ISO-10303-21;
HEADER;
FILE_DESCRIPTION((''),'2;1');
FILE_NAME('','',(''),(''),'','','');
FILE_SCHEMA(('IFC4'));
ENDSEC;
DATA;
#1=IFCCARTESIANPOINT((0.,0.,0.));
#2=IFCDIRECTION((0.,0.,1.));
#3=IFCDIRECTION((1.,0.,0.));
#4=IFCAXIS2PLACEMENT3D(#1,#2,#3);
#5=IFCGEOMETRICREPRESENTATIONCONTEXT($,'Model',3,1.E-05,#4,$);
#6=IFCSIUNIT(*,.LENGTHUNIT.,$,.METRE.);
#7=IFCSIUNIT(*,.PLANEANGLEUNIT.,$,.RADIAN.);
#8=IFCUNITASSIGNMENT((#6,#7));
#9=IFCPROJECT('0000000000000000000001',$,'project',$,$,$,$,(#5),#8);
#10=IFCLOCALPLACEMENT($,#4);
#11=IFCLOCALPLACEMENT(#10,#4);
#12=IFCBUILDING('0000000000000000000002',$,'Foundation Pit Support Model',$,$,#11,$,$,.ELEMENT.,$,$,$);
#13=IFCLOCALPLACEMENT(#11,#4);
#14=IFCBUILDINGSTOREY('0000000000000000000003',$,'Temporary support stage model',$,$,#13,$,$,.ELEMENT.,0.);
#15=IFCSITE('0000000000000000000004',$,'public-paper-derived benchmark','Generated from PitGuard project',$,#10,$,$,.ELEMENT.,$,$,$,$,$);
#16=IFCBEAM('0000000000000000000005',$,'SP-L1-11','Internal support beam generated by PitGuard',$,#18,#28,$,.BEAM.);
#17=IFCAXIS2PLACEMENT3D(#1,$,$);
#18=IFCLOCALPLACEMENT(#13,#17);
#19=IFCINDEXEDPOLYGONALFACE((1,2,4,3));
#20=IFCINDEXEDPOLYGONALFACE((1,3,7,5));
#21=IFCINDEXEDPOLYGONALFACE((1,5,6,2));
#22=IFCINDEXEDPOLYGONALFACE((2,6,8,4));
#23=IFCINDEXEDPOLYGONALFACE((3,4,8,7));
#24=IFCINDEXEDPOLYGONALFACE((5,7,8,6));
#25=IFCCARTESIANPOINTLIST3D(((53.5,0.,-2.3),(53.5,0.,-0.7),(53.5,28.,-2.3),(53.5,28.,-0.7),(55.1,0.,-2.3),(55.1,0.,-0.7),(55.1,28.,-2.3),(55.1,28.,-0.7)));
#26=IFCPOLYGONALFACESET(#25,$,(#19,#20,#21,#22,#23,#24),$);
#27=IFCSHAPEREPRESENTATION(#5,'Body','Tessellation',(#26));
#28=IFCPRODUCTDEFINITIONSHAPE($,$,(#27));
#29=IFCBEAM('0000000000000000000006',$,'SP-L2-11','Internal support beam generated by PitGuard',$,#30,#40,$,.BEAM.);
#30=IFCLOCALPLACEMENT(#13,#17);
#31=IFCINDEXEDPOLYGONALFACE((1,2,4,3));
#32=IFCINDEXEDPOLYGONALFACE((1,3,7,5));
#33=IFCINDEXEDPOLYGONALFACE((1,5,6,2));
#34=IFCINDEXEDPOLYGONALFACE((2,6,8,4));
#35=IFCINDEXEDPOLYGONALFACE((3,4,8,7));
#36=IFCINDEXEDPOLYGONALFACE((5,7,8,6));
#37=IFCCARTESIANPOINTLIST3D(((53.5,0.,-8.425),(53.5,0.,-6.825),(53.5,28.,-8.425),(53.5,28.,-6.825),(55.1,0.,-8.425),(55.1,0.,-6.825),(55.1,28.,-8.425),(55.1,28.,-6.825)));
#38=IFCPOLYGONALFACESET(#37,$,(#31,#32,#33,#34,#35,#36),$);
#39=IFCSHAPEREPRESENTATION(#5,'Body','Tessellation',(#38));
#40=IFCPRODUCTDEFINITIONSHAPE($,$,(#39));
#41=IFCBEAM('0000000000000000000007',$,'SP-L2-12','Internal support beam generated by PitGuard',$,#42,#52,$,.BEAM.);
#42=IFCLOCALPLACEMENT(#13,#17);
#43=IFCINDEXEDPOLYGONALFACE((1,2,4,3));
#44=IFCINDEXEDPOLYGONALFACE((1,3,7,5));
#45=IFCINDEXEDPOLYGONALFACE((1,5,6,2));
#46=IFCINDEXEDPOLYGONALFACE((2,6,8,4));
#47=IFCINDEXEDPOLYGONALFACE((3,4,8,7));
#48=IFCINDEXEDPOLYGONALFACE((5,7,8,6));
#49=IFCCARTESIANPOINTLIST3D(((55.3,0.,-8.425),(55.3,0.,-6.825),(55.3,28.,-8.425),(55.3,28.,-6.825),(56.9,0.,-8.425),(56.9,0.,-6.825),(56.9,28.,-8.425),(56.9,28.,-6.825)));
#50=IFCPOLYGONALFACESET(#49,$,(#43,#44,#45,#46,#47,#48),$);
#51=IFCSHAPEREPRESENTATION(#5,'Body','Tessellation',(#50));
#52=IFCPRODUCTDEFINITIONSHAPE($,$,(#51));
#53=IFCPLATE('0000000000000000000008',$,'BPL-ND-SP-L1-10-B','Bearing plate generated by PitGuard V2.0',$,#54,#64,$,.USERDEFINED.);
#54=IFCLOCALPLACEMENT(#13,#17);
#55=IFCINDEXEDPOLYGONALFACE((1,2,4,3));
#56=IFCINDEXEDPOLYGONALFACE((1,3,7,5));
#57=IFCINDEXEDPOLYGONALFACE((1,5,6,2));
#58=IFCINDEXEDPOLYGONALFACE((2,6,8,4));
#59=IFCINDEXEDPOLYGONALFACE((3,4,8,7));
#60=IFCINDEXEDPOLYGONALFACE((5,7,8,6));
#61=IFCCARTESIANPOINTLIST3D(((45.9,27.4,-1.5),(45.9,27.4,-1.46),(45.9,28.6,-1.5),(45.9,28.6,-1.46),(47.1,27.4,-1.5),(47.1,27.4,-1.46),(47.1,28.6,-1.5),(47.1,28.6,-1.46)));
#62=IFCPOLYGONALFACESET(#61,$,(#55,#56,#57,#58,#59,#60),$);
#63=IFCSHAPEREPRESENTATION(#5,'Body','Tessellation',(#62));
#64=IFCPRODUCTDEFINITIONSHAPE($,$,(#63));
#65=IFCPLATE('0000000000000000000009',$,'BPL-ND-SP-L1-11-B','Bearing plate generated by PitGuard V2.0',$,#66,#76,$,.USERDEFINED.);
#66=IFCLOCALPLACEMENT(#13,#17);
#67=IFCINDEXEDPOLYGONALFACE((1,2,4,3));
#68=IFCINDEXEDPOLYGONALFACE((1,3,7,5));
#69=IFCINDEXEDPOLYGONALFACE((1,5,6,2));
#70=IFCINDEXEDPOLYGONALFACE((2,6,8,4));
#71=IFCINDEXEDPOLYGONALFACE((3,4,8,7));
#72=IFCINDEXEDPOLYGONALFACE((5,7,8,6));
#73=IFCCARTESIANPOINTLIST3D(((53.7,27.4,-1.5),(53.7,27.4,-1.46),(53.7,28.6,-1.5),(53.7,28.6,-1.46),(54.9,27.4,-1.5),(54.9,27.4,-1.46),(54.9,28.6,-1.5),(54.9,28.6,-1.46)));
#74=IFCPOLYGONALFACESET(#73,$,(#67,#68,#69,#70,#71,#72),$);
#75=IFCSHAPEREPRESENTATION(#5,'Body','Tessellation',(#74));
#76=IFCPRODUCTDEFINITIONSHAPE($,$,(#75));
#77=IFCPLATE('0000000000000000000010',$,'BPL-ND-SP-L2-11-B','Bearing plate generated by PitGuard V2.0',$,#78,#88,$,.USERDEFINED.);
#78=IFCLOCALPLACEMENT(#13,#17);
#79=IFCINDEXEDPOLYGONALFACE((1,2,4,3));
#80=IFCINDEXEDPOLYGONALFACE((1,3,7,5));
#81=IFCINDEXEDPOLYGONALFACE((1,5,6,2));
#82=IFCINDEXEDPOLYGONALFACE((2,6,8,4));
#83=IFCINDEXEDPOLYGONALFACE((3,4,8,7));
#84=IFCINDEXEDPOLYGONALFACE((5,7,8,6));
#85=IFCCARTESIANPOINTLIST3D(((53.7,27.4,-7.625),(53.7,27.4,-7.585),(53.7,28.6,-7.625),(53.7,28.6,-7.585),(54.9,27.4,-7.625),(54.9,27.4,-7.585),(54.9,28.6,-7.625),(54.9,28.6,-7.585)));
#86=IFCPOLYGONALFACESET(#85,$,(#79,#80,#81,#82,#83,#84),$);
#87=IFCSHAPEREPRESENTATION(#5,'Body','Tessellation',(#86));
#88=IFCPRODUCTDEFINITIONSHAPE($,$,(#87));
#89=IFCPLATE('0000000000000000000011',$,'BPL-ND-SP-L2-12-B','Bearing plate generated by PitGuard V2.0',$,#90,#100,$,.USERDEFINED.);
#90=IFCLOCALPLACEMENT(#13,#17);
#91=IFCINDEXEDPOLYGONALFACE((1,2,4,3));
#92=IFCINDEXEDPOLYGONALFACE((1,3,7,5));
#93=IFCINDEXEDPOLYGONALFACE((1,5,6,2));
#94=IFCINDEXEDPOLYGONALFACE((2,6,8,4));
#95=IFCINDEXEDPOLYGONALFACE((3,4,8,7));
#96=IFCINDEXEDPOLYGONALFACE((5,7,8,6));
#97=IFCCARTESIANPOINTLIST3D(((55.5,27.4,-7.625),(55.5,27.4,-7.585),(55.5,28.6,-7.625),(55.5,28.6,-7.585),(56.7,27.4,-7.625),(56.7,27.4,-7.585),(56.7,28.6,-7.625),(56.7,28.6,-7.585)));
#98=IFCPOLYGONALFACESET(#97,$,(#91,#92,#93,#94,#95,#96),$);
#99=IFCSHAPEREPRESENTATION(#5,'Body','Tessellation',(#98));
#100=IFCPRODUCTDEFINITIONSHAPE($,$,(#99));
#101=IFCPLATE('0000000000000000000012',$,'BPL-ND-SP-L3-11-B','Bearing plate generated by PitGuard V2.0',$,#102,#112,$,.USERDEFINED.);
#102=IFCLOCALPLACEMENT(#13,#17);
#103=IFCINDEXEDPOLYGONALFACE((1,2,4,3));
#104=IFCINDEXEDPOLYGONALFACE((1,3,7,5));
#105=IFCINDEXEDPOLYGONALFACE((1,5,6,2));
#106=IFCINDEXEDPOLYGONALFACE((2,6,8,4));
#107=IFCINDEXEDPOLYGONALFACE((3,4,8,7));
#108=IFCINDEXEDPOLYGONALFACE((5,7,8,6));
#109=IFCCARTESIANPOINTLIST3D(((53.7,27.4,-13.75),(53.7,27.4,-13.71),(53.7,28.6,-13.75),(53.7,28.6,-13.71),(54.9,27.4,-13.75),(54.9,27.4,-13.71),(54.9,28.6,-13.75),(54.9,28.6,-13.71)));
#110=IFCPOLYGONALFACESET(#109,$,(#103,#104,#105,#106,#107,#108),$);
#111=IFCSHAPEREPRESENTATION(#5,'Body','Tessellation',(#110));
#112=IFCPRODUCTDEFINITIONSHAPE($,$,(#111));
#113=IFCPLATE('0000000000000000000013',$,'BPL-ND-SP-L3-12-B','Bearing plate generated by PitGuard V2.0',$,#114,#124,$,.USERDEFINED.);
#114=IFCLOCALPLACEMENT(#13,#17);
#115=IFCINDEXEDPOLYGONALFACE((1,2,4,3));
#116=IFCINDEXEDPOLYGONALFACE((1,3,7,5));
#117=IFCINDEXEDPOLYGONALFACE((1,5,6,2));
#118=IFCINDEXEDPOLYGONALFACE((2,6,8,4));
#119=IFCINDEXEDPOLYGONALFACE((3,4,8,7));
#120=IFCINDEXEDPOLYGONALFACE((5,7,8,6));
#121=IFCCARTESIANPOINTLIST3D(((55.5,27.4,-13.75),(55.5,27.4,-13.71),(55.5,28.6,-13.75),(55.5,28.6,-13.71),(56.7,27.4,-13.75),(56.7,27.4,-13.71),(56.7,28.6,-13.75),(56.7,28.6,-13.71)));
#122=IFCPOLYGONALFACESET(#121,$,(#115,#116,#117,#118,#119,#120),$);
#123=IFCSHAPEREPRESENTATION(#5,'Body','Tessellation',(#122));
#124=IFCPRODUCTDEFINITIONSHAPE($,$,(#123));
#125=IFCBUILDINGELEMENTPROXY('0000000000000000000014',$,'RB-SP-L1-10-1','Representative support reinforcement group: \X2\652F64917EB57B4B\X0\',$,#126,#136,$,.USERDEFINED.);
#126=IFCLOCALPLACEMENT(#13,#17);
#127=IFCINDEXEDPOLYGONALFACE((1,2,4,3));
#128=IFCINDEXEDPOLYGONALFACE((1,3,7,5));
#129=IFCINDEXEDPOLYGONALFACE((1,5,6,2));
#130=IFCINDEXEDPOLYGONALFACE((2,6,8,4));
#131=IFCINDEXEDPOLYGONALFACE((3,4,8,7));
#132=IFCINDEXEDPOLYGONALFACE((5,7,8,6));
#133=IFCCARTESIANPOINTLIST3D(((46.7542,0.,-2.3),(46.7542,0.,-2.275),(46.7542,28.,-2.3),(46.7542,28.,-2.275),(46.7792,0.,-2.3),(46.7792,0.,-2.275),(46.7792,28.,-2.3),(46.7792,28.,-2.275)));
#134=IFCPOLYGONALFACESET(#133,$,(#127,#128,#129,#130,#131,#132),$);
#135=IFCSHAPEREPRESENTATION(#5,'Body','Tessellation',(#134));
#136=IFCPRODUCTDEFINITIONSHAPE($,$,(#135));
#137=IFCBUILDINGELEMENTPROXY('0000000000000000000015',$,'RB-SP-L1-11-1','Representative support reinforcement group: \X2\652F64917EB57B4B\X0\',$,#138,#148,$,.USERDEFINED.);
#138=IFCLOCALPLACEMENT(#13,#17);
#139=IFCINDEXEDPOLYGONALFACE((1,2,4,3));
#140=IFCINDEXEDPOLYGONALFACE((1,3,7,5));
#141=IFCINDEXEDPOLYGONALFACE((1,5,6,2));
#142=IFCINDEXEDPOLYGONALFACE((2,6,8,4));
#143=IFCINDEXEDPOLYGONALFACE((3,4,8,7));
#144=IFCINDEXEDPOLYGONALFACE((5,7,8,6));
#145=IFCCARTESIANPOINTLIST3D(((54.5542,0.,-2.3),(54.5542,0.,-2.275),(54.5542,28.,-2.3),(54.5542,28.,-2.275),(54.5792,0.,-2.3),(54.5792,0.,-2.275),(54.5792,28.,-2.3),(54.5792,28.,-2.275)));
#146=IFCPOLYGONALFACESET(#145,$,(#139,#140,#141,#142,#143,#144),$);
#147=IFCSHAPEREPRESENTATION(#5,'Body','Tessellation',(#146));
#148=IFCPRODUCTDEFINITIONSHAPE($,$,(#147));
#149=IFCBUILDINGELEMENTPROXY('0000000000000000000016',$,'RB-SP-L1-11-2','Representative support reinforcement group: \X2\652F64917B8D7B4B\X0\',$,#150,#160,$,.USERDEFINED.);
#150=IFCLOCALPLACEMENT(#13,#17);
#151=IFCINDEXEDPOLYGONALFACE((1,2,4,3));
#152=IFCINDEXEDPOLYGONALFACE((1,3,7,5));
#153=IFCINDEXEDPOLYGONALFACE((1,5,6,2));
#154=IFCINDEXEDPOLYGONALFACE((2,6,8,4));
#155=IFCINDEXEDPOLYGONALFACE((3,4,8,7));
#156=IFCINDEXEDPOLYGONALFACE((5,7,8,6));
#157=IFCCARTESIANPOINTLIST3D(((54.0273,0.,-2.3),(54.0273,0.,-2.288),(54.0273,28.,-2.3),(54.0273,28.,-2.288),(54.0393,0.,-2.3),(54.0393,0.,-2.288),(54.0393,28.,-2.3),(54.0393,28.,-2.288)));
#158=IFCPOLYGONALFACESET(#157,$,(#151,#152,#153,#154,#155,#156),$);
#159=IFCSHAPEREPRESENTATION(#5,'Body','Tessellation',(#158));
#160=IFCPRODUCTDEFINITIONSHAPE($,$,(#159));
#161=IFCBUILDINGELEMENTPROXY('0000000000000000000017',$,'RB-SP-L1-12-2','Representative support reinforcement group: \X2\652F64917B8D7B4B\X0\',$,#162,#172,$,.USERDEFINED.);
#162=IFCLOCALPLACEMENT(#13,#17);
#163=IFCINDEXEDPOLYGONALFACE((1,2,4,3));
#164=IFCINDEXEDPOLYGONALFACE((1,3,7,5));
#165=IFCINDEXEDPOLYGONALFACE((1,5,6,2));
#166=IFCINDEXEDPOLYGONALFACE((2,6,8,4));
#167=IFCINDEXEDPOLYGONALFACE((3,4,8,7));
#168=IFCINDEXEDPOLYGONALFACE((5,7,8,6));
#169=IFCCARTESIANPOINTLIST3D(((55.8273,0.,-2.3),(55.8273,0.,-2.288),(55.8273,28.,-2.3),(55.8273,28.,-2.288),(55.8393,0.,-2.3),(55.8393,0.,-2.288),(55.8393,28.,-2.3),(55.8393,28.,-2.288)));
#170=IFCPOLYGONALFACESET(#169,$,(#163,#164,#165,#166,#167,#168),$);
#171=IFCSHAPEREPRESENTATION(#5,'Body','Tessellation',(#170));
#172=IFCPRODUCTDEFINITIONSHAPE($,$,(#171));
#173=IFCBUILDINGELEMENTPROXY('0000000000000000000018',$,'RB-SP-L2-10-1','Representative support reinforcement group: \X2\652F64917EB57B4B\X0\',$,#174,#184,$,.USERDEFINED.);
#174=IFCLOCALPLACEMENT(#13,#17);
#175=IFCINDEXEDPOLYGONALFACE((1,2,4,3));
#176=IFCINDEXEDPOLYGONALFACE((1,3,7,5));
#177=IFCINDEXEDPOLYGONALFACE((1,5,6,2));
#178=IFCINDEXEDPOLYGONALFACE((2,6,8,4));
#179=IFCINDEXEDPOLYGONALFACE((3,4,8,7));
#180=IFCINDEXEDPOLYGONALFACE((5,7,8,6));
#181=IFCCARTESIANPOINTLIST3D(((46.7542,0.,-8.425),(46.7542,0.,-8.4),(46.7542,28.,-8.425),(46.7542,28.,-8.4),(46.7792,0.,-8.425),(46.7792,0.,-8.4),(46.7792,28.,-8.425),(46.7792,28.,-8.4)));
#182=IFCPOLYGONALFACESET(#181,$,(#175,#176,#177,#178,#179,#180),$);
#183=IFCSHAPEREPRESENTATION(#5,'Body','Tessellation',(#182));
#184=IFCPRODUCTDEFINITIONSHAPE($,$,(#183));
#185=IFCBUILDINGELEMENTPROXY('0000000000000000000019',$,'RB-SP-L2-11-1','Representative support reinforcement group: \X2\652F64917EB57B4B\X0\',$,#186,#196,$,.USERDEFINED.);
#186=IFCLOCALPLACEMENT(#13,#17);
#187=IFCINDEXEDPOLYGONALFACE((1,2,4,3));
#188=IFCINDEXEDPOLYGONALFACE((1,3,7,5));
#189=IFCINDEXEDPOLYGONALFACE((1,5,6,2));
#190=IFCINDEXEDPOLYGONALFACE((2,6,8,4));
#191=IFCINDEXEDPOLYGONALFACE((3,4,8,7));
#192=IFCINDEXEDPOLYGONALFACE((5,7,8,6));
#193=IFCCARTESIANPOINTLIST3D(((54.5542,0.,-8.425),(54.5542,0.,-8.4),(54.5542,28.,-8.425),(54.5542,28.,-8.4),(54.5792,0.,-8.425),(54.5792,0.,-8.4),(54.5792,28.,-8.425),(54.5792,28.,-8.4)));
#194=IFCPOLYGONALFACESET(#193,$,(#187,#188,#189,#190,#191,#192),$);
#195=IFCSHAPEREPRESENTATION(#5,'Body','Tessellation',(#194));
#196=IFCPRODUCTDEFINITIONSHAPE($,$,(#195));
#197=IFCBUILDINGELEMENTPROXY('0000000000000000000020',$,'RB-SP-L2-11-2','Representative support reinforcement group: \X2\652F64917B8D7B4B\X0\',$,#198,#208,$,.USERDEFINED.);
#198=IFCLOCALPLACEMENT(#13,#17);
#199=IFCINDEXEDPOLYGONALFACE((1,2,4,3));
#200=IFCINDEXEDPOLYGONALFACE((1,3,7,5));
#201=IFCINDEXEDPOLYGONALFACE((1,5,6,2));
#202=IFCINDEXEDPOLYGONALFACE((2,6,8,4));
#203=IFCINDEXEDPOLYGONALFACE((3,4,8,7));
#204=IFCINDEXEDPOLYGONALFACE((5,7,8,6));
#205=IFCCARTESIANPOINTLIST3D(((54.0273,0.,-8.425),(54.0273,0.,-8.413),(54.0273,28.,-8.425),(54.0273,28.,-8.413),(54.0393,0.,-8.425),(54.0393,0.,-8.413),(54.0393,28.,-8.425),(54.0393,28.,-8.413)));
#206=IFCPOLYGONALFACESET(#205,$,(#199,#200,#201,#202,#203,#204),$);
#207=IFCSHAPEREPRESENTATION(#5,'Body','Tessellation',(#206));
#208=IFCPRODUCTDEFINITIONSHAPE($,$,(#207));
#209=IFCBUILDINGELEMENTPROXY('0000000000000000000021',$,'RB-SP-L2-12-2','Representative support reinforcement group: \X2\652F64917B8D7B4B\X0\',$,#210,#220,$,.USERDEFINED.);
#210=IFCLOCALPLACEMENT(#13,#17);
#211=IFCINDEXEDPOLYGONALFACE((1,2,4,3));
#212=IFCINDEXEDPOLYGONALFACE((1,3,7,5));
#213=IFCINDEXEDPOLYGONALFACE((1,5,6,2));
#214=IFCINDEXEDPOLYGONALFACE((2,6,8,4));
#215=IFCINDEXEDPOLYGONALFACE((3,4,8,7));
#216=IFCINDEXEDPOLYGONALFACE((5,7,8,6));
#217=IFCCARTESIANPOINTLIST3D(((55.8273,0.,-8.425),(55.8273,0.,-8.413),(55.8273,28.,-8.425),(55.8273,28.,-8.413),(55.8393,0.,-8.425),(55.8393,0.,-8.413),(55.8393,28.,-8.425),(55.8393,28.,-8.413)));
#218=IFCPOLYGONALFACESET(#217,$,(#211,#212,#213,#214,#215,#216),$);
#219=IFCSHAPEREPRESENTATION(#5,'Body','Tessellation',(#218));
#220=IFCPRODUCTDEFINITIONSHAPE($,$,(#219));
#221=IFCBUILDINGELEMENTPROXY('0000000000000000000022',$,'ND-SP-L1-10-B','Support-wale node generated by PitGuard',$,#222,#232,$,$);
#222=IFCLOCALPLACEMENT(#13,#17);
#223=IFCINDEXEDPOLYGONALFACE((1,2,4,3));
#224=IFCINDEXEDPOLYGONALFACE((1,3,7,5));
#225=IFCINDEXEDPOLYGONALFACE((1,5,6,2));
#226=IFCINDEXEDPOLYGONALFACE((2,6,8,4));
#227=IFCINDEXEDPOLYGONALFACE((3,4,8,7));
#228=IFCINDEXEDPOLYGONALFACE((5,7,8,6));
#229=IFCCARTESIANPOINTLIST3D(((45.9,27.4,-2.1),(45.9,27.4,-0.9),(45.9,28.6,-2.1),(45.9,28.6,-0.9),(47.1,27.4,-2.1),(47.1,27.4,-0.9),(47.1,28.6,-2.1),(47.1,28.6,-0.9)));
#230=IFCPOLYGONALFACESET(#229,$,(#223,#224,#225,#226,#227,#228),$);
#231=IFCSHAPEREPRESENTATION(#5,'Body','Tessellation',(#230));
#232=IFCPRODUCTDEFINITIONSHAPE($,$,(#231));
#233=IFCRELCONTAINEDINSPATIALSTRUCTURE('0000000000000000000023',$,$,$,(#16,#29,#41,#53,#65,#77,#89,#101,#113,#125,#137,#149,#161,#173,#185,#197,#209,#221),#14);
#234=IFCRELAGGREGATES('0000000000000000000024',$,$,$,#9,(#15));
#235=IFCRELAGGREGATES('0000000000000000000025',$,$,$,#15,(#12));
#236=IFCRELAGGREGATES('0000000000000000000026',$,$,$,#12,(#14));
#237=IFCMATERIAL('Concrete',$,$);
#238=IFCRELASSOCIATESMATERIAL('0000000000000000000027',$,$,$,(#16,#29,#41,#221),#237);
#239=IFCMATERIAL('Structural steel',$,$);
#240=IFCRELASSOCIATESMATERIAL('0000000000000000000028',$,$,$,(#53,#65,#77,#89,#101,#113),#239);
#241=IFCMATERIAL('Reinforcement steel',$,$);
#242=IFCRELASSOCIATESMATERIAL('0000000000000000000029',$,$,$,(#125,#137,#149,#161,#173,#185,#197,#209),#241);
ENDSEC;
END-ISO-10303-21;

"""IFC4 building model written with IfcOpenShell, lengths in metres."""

from ifc_helpers import new_model, si_unit, frame, origin_with_axes, origin_2d, place, context, project, spatial, rectangle, extrude, material, element, save


model = new_model("IFC4")

# Units and contexts
model_context = context("Model", 3, precision=1e-05, world=origin_with_axes())
ifc_project = project(units=[si_unit("LENGTHUNIT", "METRE"), si_unit("PLANEANGLEUNIT", "RADIAN")], contexts=[model_context])

# Site, building, storey
site_placement = place(None, origin_with_axes())
site = spatial("IfcSite", under=ifc_project, at=site_placement, Name="public-paper-derived benchmark", Description="Generated from PitGuard project", CompositionType="ELEMENT")
building_placement = place(site_placement, origin_with_axes())
building = spatial("IfcBuilding", under=site, at=building_placement, Name="Foundation Pit Support Model", CompositionType="ELEMENT")
storey_placement = place(building_placement, origin_with_axes())
storey = spatial("IfcBuildingStorey", under=building, at=storey_placement, Name="Temporary support stage model", CompositionType="ELEMENT", Elevation=0.0)

# Beams
ifc_material_1 = material(Name="Concrete")
for number, where, z_axis, x_axis, name in (
    (1, (54.3, 14.0, -2.3), (0.0, 0.0, 1.0), (0.0, 1.0, 0.0), "SP-L1-11"),
    (2, (54.3, 14.0, -8.425), (0.0, 0.0, 1.0), (0.0, 1.0, 0.0), "SP-L2-11"),
    (3, (56.1, 14.0, -8.425), (0.0, 0.0, 1.0), (0.0, 1.0, 0.0), "SP-L2-12"),
):
    element("IfcBeam", number, at=place(storey_placement, frame(where, z_axis=z_axis, x_axis=x_axis)), inside=storey, material=ifc_material_1, Name=name, Description="Internal support beam generated by PitGuard", PredefinedType="BEAM", context=model_context, shape_type="SweptSolid", body=[
        extrude(rectangle(XDim=28.0, YDim=1.6, at=origin_2d()), origin_with_axes(), (0.0, 0.0, 1.0), 1.6),
    ])

# Plates
ifc_material_2 = material(Name="Structural steel")
for number, where, z_axis, x_axis, name in (
    (4, (46.5, 28.0, -1.5), (0.0, 0.0, 1.0), (1.0, 0.0, 0.0), "BPL-ND-SP-L1-10-B"),
    (5, (54.3, 28.0, -1.5), (0.0, 0.0, 1.0), (1.0, 0.0, 0.0), "BPL-ND-SP-L1-11-B"),
    (6, (54.3, 28.0, -7.625), (0.0, 0.0, 1.0), (1.0, 0.0, 0.0), "BPL-ND-SP-L2-11-B"),
    (7, (56.1, 28.0, -7.625), (0.0, 0.0, 1.0), (1.0, 0.0, 0.0), "BPL-ND-SP-L2-12-B"),
    (8, (54.3, 28.0, -13.75), (0.0, 0.0, 1.0), (1.0, 0.0, 0.0), "BPL-ND-SP-L3-11-B"),
    (9, (56.1, 28.0, -13.75), (0.0, 0.0, 1.0), (1.0, 0.0, 0.0), "BPL-ND-SP-L3-12-B"),
):
    element("IfcPlate", number, at=place(storey_placement, frame(where, z_axis=z_axis, x_axis=x_axis)), inside=storey, material=ifc_material_2, Name=name, Description="Bearing plate generated by PitGuard V2.0", PredefinedType="USERDEFINED", context=model_context, shape_type="SweptSolid", body=[
        extrude(rectangle(XDim=1.2, YDim=1.2, at=origin_2d()), origin_with_axes(), (0.0, 0.0, 1.0), 0.04),
    ])

# Building element proxies
ifc_material_3 = material(Name="Reinforcement steel")
for number, where, z_axis, x_axis, name in (
    (10, (46.7667, 14.0, -2.3), (0.0, 0.0, 1.0), (0.0, 1.0, 0.0), "RB-SP-L1-10-1"),
    (11, (54.5667, 14.0, -2.3), (0.0, 0.0, 1.0), (0.0, 1.0, 0.0), "RB-SP-L1-11-1"),
):
    element("IfcBuildingElementProxy", number, at=place(storey_placement, frame(where, z_axis=z_axis, x_axis=x_axis)), inside=storey, material=ifc_material_3, Name=name, Description="Representative support reinforcement group: 支撑纵筋", PredefinedType="USERDEFINED", context=model_context, shape_type="SweptSolid", body=[
        extrude(rectangle(XDim=28.0, YDim=0.025, at=origin_2d()), origin_with_axes(), (0.0, 0.0, 1.0), 0.025),
    ])
for number, where, z_axis, x_axis, name in (
    (12, (54.0333, 14.0, -2.3), (0.0, 0.0, 1.0), (0.0, 1.0, 0.0), "RB-SP-L1-11-2"),
    (13, (55.8333, 14.0, -2.3), (0.0, 0.0, 1.0), (0.0, 1.0, 0.0), "RB-SP-L1-12-2"),
):
    element("IfcBuildingElementProxy", number, at=place(storey_placement, frame(where, z_axis=z_axis, x_axis=x_axis)), inside=storey, material=ifc_material_3, Name=name, Description="Representative support reinforcement group: 支撑箍筋", PredefinedType="USERDEFINED", context=model_context, shape_type="SweptSolid", body=[
        extrude(rectangle(XDim=28.0, YDim=0.012, at=origin_2d()), origin_with_axes(), (0.0, 0.0, 1.0), 0.012),
    ])
for number, where, z_axis, x_axis, name in (
    (14, (46.7667, 14.0, -8.425), (0.0, 0.0, 1.0), (0.0, 1.0, 0.0), "RB-SP-L2-10-1"),
    (15, (54.5667, 14.0, -8.425), (0.0, 0.0, 1.0), (0.0, 1.0, 0.0), "RB-SP-L2-11-1"),
):
    element("IfcBuildingElementProxy", number, at=place(storey_placement, frame(where, z_axis=z_axis, x_axis=x_axis)), inside=storey, material=ifc_material_3, Name=name, Description="Representative support reinforcement group: 支撑纵筋", PredefinedType="USERDEFINED", context=model_context, shape_type="SweptSolid", body=[
        extrude(rectangle(XDim=28.0, YDim=0.025, at=origin_2d()), origin_with_axes(), (0.0, 0.0, 1.0), 0.025),
    ])
for number, where, z_axis, x_axis, name in (
    (16, (54.0333, 14.0, -8.425), (0.0, 0.0, 1.0), (0.0, 1.0, 0.0), "RB-SP-L2-11-2"),
    (17, (55.8333, 14.0, -8.425), (0.0, 0.0, 1.0), (0.0, 1.0, 0.0), "RB-SP-L2-12-2"),
):
    element("IfcBuildingElementProxy", number, at=place(storey_placement, frame(where, z_axis=z_axis, x_axis=x_axis)), inside=storey, material=ifc_material_3, Name=name, Description="Representative support reinforcement group: 支撑箍筋", PredefinedType="USERDEFINED", context=model_context, shape_type="SweptSolid", body=[
        extrude(rectangle(XDim=28.0, YDim=0.012, at=origin_2d()), origin_with_axes(), (0.0, 0.0, 1.0), 0.012),
    ])
proxy_1_placement = place(storey_placement, frame((46.5, 28.0, -2.1), z_axis=(0.0, 0.0, 1.0), x_axis=(1.0, 0.0, 0.0)))
element("IfcBuildingElementProxy", 18, at=proxy_1_placement, inside=storey, material=ifc_material_1, Name="ND-SP-L1-10-B", Description="Support-wale node generated by PitGuard", context=model_context, shape_type="SweptSolid", body=[
    extrude(rectangle(XDim=1.2, YDim=1.2, at=origin_2d()), origin_with_axes(), (0.0, 0.0, 1.0), 1.2),
])

save(model, "model.ifc")
